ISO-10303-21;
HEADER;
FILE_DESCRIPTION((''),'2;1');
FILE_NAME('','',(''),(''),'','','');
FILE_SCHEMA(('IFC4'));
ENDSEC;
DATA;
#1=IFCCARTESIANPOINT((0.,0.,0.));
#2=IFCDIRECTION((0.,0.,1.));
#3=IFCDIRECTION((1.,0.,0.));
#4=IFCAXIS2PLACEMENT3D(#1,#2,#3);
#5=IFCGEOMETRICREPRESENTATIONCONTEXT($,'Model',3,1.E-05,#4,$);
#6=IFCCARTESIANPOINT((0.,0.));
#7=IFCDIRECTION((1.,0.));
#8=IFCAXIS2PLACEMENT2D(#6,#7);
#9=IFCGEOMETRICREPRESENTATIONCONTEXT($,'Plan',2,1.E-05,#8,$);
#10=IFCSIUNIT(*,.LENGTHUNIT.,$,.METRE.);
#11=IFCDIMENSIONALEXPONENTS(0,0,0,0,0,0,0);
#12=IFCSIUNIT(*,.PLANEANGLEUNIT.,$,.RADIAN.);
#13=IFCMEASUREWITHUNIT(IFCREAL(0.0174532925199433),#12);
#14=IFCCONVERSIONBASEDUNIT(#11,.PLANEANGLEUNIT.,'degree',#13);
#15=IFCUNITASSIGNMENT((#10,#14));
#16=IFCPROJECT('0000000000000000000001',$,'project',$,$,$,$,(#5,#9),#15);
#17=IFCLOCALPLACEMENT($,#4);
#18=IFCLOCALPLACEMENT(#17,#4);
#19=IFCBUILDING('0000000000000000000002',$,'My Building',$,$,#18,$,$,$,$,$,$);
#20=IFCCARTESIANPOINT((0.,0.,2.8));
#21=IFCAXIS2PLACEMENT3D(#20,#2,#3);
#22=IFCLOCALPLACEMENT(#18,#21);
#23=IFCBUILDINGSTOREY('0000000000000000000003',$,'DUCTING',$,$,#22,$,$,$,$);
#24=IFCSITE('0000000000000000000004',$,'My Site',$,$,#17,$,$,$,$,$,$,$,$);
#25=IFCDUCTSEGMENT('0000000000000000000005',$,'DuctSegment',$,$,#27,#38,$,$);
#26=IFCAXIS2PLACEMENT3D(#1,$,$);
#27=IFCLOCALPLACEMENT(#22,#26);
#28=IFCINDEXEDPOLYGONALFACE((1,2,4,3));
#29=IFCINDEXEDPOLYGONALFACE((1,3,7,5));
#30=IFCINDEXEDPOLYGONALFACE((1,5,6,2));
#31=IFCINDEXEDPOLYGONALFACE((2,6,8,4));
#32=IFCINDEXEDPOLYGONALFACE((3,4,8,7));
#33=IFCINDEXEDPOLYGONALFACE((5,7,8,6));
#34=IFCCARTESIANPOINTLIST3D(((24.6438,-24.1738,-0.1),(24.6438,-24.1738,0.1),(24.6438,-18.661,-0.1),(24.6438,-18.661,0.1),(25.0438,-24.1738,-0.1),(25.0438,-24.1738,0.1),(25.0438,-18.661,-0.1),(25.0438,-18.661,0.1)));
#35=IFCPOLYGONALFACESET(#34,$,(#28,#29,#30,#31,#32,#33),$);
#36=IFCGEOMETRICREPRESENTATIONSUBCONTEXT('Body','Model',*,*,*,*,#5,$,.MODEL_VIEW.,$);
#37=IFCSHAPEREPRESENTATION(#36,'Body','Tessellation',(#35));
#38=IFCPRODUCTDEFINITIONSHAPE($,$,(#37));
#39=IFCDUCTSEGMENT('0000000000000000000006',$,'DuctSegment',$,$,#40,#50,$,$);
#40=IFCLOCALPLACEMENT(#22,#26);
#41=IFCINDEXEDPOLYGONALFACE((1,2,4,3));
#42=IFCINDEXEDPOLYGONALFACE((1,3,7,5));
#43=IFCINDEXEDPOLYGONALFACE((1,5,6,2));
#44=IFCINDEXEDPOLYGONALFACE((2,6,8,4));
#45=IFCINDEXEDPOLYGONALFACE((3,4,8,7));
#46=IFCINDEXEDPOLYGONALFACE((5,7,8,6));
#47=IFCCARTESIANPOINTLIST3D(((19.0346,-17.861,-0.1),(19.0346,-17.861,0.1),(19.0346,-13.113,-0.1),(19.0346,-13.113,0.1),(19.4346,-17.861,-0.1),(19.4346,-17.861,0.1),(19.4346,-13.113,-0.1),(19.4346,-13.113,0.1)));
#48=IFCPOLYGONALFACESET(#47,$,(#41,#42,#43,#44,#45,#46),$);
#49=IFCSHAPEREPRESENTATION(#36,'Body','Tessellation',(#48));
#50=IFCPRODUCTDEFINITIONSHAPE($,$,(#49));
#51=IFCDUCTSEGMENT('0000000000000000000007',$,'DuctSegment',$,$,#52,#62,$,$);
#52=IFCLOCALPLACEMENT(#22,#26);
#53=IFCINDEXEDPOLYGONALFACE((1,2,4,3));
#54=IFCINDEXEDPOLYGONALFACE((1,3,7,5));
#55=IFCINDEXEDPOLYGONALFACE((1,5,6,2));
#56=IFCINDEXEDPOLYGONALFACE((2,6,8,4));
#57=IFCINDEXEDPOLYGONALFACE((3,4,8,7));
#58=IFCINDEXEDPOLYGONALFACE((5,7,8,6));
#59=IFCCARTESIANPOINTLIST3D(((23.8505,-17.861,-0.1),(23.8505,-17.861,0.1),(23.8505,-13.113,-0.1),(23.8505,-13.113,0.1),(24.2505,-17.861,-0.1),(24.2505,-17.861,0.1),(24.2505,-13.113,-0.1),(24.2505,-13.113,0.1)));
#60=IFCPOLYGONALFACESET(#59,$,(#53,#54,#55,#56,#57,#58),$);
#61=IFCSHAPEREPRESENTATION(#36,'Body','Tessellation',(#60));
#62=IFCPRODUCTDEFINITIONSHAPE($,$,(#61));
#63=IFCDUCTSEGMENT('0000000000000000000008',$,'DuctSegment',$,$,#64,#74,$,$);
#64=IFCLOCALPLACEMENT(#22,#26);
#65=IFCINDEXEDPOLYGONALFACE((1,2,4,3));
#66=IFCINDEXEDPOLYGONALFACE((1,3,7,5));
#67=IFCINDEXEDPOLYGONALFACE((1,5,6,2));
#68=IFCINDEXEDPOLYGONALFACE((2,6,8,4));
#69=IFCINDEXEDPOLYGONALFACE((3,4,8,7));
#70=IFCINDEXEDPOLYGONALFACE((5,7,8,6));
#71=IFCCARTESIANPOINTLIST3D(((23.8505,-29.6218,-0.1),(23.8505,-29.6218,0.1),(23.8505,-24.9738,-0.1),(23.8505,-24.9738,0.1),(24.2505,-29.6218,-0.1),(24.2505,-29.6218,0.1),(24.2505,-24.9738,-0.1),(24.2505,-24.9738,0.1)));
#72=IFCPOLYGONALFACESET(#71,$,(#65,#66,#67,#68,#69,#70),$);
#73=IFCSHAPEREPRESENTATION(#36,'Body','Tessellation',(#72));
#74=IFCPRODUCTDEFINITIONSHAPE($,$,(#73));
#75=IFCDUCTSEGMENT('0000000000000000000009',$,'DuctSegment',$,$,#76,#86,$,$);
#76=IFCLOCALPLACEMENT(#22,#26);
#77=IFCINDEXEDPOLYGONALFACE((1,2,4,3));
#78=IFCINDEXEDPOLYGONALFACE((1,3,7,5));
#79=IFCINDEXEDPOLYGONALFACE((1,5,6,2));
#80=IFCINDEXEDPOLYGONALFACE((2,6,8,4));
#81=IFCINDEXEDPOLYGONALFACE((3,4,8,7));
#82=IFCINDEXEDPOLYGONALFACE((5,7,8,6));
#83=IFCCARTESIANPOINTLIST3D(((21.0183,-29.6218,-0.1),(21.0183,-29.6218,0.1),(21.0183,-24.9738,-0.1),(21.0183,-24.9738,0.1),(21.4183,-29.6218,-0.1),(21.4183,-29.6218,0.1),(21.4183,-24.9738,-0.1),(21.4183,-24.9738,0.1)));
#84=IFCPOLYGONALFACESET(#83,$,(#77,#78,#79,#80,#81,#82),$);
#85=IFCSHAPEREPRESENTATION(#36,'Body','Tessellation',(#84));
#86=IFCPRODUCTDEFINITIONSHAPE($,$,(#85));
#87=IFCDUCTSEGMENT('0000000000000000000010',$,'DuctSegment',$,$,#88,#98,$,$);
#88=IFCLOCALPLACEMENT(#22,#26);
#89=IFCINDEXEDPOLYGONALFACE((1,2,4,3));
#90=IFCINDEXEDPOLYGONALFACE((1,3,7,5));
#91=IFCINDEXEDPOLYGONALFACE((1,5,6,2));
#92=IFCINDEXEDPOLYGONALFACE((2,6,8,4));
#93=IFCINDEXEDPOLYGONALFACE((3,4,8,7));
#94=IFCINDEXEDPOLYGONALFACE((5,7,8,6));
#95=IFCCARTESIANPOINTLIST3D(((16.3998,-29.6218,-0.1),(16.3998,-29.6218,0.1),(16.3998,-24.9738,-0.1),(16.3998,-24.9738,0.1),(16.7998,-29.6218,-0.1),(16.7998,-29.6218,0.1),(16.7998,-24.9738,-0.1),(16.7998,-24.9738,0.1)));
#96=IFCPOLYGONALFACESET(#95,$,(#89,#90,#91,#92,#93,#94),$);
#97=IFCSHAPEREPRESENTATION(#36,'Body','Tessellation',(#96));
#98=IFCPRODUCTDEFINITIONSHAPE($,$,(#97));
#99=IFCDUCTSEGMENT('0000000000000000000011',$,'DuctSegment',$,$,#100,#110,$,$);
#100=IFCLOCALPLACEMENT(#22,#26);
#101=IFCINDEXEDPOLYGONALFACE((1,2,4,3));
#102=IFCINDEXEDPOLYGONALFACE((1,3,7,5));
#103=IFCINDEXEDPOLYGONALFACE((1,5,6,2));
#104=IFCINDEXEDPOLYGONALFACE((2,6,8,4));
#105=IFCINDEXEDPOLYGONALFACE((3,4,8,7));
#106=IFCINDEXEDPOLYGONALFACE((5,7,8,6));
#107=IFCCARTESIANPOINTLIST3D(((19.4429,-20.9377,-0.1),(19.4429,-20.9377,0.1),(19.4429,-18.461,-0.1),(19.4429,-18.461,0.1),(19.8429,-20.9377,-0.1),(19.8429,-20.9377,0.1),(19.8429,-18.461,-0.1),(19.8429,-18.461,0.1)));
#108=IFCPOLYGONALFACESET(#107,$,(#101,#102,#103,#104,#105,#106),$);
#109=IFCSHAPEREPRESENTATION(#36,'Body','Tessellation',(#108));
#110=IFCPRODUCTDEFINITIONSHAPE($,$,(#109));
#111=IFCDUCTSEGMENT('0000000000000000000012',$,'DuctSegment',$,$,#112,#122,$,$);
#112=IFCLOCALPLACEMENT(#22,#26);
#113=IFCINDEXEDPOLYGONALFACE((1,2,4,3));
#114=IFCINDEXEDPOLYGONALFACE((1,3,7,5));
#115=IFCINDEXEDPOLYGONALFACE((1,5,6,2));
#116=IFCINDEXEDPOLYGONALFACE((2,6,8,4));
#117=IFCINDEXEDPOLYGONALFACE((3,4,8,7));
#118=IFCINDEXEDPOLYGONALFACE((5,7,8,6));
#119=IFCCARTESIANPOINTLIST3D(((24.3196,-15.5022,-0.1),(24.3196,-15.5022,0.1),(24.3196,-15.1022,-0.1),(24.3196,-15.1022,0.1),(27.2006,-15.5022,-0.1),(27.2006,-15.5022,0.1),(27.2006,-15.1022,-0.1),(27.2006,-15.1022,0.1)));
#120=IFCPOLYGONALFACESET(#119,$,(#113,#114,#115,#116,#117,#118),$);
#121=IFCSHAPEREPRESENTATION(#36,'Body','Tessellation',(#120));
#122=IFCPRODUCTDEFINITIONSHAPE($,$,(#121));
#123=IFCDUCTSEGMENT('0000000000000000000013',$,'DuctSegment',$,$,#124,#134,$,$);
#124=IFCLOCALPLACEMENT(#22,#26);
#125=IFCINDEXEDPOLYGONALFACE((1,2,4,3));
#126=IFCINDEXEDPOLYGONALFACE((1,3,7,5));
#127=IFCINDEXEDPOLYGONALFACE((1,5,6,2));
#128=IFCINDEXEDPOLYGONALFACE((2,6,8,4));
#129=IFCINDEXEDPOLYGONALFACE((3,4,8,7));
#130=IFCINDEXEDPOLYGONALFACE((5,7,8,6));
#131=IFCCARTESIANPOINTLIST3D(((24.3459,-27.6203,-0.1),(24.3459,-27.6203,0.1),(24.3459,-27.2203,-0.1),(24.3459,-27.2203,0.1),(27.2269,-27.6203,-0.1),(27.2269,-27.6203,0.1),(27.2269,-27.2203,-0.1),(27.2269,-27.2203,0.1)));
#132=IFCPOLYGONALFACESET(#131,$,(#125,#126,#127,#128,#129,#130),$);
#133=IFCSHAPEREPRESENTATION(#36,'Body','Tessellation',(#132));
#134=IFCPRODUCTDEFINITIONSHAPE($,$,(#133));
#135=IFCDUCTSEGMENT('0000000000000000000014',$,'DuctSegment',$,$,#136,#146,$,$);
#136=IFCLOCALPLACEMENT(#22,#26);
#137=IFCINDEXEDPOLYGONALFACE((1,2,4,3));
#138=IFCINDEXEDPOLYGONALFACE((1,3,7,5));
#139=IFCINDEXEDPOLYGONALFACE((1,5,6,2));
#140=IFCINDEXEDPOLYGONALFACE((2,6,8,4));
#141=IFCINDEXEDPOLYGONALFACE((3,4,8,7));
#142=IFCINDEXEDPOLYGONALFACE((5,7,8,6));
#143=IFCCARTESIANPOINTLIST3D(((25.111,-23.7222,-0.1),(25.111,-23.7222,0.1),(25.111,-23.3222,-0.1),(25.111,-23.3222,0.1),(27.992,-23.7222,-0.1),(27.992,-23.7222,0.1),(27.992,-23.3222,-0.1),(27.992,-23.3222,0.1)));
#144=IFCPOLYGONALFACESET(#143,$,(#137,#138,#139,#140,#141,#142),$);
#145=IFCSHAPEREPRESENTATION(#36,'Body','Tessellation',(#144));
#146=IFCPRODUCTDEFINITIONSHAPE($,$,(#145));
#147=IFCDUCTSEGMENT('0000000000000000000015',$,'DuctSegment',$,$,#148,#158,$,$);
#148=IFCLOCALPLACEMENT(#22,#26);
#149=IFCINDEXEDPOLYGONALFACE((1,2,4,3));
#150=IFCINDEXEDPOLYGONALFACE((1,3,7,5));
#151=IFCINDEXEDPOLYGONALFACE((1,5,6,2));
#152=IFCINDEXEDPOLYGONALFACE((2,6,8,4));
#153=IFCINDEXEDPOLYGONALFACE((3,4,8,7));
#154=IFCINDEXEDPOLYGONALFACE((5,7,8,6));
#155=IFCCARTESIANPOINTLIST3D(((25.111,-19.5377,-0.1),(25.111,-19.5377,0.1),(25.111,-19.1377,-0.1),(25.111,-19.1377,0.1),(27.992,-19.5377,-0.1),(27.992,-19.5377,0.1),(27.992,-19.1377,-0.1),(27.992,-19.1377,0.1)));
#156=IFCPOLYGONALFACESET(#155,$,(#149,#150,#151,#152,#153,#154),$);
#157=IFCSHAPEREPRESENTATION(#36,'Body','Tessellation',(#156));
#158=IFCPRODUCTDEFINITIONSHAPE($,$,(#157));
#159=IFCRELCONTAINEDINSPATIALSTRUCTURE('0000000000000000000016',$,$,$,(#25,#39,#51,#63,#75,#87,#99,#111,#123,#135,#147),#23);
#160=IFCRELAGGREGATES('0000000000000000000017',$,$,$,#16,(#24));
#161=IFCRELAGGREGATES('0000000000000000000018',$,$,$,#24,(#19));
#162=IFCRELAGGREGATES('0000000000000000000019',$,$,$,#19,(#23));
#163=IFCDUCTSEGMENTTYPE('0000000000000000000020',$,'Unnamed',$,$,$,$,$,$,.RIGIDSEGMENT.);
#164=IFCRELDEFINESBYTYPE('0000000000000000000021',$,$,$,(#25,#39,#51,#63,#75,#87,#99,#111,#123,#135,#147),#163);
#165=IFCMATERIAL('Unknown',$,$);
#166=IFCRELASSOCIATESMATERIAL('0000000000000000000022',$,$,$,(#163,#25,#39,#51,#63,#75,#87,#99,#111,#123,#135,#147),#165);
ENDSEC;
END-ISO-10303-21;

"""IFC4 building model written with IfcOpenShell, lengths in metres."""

from ifc_helpers import new_model, entity, si_unit, converted_unit, frame, origin_with_axes, origin_2d_with_axis, place, context, subcontext, project, spatial, rectangle, extrude, material, material_profile, profile_set, profile_usage, type_object, element, save


model = new_model("IFC4")

# Units and contexts
model_context = context("Model", 3, precision=1e-05, world=origin_with_axes())
plan_context = context("Plan", 2, precision=1e-05, world=origin_2d_with_axis())
body_context = subcontext(model_context, "Body", "Model", "MODEL_VIEW")
ifc_project = project(units=[si_unit("LENGTHUNIT", "METRE"), converted_unit("PLANEANGLEUNIT", "degree", entity("IfcReal", 0.0174532925199433), si_unit("PLANEANGLEUNIT", "RADIAN"), dimensions=[0, 0, 0, 0, 0, 0, 0])], contexts=[model_context, plan_context])

# Site, building, storey
site_placement = place(None, origin_with_axes())
site = spatial("IfcSite", under=ifc_project, at=site_placement, Name="My Site")
building_placement = place(site_placement, origin_with_axes())
building = spatial("IfcBuilding", under=site, at=building_placement, Name="My Building")
storey_placement = place(building_placement, frame((0.0, 0.0, 2.8), z_axis=(0.0, 0.0, 1.0), x_axis=(1.0, 0.0, 0.0)))
storey = spatial("IfcBuildingStorey", under=building, at=storey_placement, Name="DUCTING")

# Duct segments
ifc_material = material(Name="Unknown")
ifc_material_profile_1 = material_profile(ifc_material, rectangle(XDim=0.4, YDim=0.2))
ifc_profile_set_1 = profile_set([ifc_material_profile_1])
ifc_profile_usage_1 = profile_usage(ifc_profile_set_1, cardinal=5)
duct_segment_type = type_object("IfcDuctSegmentType", Name="Unnamed", PredefinedType="RIGIDSEGMENT", material=ifc_profile_set_1)
duct_segment_1_placement = place(storey_placement, frame((24.8438, -18.661, 0.0), z_axis=(0.0, -1.0, 0.0), x_axis=(1.0, 0.0, 0.0)))
element("IfcDuctSegment", 1, at=duct_segment_1_placement, inside=storey, type_object=duct_segment_type, material=ifc_profile_usage_1, Name="DuctSegment", context=body_context, shape_type="SweptSolid", body=[
    extrude(rectangle(XDim=0.4, YDim=0.2), origin_with_axes(), (0.0, 0.0, 1.0), 5.5127),
])
ifc_profile_usage_2 = profile_usage(ifc_profile_set_1, cardinal=5)
duct_segment_2_placement = place(storey_placement, frame((19.2346, -17.861, 0.0), z_axis=(0.0, 1.0, 0.0), x_axis=(-1.0, 0.0, 0.0)))
element("IfcDuctSegment", 2, at=duct_segment_2_placement, inside=storey, type_object=duct_segment_type, material=ifc_profile_usage_2, Name="DuctSegment", context=body_context, shape_type="SweptSolid", body=[
    extrude(rectangle(XDim=0.4, YDim=0.2), origin_with_axes(), (0.0, 0.0, 1.0), 4.7481),
])
ifc_profile_usage_3 = profile_usage(ifc_profile_set_1, cardinal=5)
duct_segment_3_placement = place(storey_placement, frame((24.0505, -17.861, 0.0), z_axis=(0.0, 1.0, 0.0), x_axis=(-1.0, 0.0, 0.0)))
element("IfcDuctSegment", 3, at=duct_segment_3_placement, inside=storey, type_object=duct_segment_type, material=ifc_profile_usage_3, Name="DuctSegment", context=body_context, shape_type="SweptSolid", body=[
    extrude(rectangle(XDim=0.4, YDim=0.2), origin_with_axes(), (0.0, 0.0, 1.0), 4.7481),
])
ifc_profile_usage_4 = profile_usage(ifc_profile_set_1, cardinal=5)
duct_segment_4_placement = place(storey_placement, frame((24.0505, -24.9738, 0.0), z_axis=(0.0, -1.0, 0.0), x_axis=(1.0, 0.0, 0.0)))
element("IfcDuctSegment", 4, at=duct_segment_4_placement, inside=storey, type_object=duct_segment_type, material=ifc_profile_usage_4, Name="DuctSegment", context=body_context, shape_type="SweptSolid", body=[
    extrude(rectangle(XDim=0.4, YDim=0.2), origin_with_axes(), (0.0, 0.0, 1.0), 4.6481),
])
ifc_profile_usage_5 = profile_usage(ifc_profile_set_1, cardinal=5)
duct_segment_5_placement = place(storey_placement, frame((21.2183, -24.9738, 0.0), z_axis=(0.0, -1.0, 0.0), x_axis=(1.0, 0.0, 0.0)))
element("IfcDuctSegment", 5, at=duct_segment_5_placement, inside=storey, type_object=duct_segment_type, material=ifc_profile_usage_5, Name="DuctSegment", context=body_context, shape_type="SweptSolid", body=[
    extrude(rectangle(XDim=0.4, YDim=0.2), origin_with_axes(), (0.0, 0.0, 1.0), 4.6481),
])
ifc_profile_usage_6 = profile_usage(ifc_profile_set_1, cardinal=5)
duct_segment_6_placement = place(storey_placement, frame((16.5998, -24.9738, 0.0), z_axis=(0.0, -1.0, 0.0), x_axis=(1.0, 0.0, 0.0)))
element("IfcDuctSegment", 6, at=duct_segment_6_placement, inside=storey, type_object=duct_segment_type, material=ifc_profile_usage_6, Name="DuctSegment", context=body_context, shape_type="SweptSolid", body=[
    extrude(rectangle(XDim=0.4, YDim=0.2), origin_with_axes(), (0.0, 0.0, 1.0), 4.6481),
])
ifc_profile_usage_7 = profile_usage(ifc_profile_set_1, cardinal=5)
duct_segment_7_placement = place(storey_placement, frame((19.6429, -18.461, 0.0), z_axis=(0.0, -1.0, 0.0), x_axis=(1.0, 0.0, 0.0)))
element("IfcDuctSegment", 7, at=duct_segment_7_placement, inside=storey, type_object=duct_segment_type, material=ifc_profile_usage_7, Name="DuctSegment", context=body_context, shape_type="SweptSolid", body=[
    extrude(rectangle(XDim=0.4, YDim=0.2), origin_with_axes(), (0.0, 0.0, 1.0), 2.4767),
])
ifc_profile_usage_8 = profile_usage(ifc_profile_set_1, cardinal=5)
duct_segment_8_placement = place(storey_placement, frame((24.3196, -15.3022, 0.0), z_axis=(1.0, -0.000001, 0.000001), x_axis=(0.000001, 1.0, 0.0)))
element("IfcDuctSegment", 8, at=duct_segment_8_placement, inside=storey, type_object=duct_segment_type, material=ifc_profile_usage_8, Name="DuctSegment", context=body_context, shape_type="SweptSolid", body=[
    extrude(rectangle(XDim=0.4, YDim=0.2), origin_with_axes(), (0.0, 0.0, 1.0), 2.881),
])
ifc_profile_usage_9 = profile_usage(ifc_profile_set_1, cardinal=5)
duct_segment_9_placement = place(storey_placement, frame((24.3459, -27.4203, 0.0), z_axis=(1.0, -0.000001, 0.000001), x_axis=(0.000001, 1.0, 0.0)))
element("IfcDuctSegment", 9, at=duct_segment_9_placement, inside=storey, type_object=duct_segment_type, material=ifc_profile_usage_9, Name="DuctSegment", context=body_context, shape_type="SweptSolid", body=[
    extrude(rectangle(XDim=0.4, YDim=0.2), origin_with_axes(), (0.0, 0.0, 1.0), 2.881),
])
ifc_profile_usage_10 = profile_usage(ifc_profile_set_1, cardinal=5)
duct_segment_10_placement = place(storey_placement, frame((25.111, -23.5222, 0.0), z_axis=(1.0, -0.000001, 0.000001), x_axis=(0.000001, 1.0, 0.0)))
element("IfcDuctSegment", 10, at=duct_segment_10_placement, inside=storey, type_object=duct_segment_type, material=ifc_profile_usage_10, Name="DuctSegment", context=body_context, shape_type="SweptSolid", body=[
    extrude(rectangle(XDim=0.4, YDim=0.2), origin_with_axes(), (0.0, 0.0, 1.0), 2.881),
])
ifc_profile_usage_11 = profile_usage(ifc_profile_set_1, cardinal=5)
duct_segment_11_placement = place(storey_placement, frame((25.111, -19.3377, 0.0), z_axis=(1.0, -0.000001, 0.000001), x_axis=(0.000001, 1.0, 0.0)))
element("IfcDuctSegment", 11, at=duct_segment_11_placement, inside=storey, type_object=duct_segment_type, material=ifc_profile_usage_11, Name="DuctSegment", context=body_context, shape_type="SweptSolid", body=[
    extrude(rectangle(XDim=0.4, YDim=0.2), origin_with_axes(), (0.0, 0.0, 1.0), 2.881),
])

save(model, "model.ifc")
